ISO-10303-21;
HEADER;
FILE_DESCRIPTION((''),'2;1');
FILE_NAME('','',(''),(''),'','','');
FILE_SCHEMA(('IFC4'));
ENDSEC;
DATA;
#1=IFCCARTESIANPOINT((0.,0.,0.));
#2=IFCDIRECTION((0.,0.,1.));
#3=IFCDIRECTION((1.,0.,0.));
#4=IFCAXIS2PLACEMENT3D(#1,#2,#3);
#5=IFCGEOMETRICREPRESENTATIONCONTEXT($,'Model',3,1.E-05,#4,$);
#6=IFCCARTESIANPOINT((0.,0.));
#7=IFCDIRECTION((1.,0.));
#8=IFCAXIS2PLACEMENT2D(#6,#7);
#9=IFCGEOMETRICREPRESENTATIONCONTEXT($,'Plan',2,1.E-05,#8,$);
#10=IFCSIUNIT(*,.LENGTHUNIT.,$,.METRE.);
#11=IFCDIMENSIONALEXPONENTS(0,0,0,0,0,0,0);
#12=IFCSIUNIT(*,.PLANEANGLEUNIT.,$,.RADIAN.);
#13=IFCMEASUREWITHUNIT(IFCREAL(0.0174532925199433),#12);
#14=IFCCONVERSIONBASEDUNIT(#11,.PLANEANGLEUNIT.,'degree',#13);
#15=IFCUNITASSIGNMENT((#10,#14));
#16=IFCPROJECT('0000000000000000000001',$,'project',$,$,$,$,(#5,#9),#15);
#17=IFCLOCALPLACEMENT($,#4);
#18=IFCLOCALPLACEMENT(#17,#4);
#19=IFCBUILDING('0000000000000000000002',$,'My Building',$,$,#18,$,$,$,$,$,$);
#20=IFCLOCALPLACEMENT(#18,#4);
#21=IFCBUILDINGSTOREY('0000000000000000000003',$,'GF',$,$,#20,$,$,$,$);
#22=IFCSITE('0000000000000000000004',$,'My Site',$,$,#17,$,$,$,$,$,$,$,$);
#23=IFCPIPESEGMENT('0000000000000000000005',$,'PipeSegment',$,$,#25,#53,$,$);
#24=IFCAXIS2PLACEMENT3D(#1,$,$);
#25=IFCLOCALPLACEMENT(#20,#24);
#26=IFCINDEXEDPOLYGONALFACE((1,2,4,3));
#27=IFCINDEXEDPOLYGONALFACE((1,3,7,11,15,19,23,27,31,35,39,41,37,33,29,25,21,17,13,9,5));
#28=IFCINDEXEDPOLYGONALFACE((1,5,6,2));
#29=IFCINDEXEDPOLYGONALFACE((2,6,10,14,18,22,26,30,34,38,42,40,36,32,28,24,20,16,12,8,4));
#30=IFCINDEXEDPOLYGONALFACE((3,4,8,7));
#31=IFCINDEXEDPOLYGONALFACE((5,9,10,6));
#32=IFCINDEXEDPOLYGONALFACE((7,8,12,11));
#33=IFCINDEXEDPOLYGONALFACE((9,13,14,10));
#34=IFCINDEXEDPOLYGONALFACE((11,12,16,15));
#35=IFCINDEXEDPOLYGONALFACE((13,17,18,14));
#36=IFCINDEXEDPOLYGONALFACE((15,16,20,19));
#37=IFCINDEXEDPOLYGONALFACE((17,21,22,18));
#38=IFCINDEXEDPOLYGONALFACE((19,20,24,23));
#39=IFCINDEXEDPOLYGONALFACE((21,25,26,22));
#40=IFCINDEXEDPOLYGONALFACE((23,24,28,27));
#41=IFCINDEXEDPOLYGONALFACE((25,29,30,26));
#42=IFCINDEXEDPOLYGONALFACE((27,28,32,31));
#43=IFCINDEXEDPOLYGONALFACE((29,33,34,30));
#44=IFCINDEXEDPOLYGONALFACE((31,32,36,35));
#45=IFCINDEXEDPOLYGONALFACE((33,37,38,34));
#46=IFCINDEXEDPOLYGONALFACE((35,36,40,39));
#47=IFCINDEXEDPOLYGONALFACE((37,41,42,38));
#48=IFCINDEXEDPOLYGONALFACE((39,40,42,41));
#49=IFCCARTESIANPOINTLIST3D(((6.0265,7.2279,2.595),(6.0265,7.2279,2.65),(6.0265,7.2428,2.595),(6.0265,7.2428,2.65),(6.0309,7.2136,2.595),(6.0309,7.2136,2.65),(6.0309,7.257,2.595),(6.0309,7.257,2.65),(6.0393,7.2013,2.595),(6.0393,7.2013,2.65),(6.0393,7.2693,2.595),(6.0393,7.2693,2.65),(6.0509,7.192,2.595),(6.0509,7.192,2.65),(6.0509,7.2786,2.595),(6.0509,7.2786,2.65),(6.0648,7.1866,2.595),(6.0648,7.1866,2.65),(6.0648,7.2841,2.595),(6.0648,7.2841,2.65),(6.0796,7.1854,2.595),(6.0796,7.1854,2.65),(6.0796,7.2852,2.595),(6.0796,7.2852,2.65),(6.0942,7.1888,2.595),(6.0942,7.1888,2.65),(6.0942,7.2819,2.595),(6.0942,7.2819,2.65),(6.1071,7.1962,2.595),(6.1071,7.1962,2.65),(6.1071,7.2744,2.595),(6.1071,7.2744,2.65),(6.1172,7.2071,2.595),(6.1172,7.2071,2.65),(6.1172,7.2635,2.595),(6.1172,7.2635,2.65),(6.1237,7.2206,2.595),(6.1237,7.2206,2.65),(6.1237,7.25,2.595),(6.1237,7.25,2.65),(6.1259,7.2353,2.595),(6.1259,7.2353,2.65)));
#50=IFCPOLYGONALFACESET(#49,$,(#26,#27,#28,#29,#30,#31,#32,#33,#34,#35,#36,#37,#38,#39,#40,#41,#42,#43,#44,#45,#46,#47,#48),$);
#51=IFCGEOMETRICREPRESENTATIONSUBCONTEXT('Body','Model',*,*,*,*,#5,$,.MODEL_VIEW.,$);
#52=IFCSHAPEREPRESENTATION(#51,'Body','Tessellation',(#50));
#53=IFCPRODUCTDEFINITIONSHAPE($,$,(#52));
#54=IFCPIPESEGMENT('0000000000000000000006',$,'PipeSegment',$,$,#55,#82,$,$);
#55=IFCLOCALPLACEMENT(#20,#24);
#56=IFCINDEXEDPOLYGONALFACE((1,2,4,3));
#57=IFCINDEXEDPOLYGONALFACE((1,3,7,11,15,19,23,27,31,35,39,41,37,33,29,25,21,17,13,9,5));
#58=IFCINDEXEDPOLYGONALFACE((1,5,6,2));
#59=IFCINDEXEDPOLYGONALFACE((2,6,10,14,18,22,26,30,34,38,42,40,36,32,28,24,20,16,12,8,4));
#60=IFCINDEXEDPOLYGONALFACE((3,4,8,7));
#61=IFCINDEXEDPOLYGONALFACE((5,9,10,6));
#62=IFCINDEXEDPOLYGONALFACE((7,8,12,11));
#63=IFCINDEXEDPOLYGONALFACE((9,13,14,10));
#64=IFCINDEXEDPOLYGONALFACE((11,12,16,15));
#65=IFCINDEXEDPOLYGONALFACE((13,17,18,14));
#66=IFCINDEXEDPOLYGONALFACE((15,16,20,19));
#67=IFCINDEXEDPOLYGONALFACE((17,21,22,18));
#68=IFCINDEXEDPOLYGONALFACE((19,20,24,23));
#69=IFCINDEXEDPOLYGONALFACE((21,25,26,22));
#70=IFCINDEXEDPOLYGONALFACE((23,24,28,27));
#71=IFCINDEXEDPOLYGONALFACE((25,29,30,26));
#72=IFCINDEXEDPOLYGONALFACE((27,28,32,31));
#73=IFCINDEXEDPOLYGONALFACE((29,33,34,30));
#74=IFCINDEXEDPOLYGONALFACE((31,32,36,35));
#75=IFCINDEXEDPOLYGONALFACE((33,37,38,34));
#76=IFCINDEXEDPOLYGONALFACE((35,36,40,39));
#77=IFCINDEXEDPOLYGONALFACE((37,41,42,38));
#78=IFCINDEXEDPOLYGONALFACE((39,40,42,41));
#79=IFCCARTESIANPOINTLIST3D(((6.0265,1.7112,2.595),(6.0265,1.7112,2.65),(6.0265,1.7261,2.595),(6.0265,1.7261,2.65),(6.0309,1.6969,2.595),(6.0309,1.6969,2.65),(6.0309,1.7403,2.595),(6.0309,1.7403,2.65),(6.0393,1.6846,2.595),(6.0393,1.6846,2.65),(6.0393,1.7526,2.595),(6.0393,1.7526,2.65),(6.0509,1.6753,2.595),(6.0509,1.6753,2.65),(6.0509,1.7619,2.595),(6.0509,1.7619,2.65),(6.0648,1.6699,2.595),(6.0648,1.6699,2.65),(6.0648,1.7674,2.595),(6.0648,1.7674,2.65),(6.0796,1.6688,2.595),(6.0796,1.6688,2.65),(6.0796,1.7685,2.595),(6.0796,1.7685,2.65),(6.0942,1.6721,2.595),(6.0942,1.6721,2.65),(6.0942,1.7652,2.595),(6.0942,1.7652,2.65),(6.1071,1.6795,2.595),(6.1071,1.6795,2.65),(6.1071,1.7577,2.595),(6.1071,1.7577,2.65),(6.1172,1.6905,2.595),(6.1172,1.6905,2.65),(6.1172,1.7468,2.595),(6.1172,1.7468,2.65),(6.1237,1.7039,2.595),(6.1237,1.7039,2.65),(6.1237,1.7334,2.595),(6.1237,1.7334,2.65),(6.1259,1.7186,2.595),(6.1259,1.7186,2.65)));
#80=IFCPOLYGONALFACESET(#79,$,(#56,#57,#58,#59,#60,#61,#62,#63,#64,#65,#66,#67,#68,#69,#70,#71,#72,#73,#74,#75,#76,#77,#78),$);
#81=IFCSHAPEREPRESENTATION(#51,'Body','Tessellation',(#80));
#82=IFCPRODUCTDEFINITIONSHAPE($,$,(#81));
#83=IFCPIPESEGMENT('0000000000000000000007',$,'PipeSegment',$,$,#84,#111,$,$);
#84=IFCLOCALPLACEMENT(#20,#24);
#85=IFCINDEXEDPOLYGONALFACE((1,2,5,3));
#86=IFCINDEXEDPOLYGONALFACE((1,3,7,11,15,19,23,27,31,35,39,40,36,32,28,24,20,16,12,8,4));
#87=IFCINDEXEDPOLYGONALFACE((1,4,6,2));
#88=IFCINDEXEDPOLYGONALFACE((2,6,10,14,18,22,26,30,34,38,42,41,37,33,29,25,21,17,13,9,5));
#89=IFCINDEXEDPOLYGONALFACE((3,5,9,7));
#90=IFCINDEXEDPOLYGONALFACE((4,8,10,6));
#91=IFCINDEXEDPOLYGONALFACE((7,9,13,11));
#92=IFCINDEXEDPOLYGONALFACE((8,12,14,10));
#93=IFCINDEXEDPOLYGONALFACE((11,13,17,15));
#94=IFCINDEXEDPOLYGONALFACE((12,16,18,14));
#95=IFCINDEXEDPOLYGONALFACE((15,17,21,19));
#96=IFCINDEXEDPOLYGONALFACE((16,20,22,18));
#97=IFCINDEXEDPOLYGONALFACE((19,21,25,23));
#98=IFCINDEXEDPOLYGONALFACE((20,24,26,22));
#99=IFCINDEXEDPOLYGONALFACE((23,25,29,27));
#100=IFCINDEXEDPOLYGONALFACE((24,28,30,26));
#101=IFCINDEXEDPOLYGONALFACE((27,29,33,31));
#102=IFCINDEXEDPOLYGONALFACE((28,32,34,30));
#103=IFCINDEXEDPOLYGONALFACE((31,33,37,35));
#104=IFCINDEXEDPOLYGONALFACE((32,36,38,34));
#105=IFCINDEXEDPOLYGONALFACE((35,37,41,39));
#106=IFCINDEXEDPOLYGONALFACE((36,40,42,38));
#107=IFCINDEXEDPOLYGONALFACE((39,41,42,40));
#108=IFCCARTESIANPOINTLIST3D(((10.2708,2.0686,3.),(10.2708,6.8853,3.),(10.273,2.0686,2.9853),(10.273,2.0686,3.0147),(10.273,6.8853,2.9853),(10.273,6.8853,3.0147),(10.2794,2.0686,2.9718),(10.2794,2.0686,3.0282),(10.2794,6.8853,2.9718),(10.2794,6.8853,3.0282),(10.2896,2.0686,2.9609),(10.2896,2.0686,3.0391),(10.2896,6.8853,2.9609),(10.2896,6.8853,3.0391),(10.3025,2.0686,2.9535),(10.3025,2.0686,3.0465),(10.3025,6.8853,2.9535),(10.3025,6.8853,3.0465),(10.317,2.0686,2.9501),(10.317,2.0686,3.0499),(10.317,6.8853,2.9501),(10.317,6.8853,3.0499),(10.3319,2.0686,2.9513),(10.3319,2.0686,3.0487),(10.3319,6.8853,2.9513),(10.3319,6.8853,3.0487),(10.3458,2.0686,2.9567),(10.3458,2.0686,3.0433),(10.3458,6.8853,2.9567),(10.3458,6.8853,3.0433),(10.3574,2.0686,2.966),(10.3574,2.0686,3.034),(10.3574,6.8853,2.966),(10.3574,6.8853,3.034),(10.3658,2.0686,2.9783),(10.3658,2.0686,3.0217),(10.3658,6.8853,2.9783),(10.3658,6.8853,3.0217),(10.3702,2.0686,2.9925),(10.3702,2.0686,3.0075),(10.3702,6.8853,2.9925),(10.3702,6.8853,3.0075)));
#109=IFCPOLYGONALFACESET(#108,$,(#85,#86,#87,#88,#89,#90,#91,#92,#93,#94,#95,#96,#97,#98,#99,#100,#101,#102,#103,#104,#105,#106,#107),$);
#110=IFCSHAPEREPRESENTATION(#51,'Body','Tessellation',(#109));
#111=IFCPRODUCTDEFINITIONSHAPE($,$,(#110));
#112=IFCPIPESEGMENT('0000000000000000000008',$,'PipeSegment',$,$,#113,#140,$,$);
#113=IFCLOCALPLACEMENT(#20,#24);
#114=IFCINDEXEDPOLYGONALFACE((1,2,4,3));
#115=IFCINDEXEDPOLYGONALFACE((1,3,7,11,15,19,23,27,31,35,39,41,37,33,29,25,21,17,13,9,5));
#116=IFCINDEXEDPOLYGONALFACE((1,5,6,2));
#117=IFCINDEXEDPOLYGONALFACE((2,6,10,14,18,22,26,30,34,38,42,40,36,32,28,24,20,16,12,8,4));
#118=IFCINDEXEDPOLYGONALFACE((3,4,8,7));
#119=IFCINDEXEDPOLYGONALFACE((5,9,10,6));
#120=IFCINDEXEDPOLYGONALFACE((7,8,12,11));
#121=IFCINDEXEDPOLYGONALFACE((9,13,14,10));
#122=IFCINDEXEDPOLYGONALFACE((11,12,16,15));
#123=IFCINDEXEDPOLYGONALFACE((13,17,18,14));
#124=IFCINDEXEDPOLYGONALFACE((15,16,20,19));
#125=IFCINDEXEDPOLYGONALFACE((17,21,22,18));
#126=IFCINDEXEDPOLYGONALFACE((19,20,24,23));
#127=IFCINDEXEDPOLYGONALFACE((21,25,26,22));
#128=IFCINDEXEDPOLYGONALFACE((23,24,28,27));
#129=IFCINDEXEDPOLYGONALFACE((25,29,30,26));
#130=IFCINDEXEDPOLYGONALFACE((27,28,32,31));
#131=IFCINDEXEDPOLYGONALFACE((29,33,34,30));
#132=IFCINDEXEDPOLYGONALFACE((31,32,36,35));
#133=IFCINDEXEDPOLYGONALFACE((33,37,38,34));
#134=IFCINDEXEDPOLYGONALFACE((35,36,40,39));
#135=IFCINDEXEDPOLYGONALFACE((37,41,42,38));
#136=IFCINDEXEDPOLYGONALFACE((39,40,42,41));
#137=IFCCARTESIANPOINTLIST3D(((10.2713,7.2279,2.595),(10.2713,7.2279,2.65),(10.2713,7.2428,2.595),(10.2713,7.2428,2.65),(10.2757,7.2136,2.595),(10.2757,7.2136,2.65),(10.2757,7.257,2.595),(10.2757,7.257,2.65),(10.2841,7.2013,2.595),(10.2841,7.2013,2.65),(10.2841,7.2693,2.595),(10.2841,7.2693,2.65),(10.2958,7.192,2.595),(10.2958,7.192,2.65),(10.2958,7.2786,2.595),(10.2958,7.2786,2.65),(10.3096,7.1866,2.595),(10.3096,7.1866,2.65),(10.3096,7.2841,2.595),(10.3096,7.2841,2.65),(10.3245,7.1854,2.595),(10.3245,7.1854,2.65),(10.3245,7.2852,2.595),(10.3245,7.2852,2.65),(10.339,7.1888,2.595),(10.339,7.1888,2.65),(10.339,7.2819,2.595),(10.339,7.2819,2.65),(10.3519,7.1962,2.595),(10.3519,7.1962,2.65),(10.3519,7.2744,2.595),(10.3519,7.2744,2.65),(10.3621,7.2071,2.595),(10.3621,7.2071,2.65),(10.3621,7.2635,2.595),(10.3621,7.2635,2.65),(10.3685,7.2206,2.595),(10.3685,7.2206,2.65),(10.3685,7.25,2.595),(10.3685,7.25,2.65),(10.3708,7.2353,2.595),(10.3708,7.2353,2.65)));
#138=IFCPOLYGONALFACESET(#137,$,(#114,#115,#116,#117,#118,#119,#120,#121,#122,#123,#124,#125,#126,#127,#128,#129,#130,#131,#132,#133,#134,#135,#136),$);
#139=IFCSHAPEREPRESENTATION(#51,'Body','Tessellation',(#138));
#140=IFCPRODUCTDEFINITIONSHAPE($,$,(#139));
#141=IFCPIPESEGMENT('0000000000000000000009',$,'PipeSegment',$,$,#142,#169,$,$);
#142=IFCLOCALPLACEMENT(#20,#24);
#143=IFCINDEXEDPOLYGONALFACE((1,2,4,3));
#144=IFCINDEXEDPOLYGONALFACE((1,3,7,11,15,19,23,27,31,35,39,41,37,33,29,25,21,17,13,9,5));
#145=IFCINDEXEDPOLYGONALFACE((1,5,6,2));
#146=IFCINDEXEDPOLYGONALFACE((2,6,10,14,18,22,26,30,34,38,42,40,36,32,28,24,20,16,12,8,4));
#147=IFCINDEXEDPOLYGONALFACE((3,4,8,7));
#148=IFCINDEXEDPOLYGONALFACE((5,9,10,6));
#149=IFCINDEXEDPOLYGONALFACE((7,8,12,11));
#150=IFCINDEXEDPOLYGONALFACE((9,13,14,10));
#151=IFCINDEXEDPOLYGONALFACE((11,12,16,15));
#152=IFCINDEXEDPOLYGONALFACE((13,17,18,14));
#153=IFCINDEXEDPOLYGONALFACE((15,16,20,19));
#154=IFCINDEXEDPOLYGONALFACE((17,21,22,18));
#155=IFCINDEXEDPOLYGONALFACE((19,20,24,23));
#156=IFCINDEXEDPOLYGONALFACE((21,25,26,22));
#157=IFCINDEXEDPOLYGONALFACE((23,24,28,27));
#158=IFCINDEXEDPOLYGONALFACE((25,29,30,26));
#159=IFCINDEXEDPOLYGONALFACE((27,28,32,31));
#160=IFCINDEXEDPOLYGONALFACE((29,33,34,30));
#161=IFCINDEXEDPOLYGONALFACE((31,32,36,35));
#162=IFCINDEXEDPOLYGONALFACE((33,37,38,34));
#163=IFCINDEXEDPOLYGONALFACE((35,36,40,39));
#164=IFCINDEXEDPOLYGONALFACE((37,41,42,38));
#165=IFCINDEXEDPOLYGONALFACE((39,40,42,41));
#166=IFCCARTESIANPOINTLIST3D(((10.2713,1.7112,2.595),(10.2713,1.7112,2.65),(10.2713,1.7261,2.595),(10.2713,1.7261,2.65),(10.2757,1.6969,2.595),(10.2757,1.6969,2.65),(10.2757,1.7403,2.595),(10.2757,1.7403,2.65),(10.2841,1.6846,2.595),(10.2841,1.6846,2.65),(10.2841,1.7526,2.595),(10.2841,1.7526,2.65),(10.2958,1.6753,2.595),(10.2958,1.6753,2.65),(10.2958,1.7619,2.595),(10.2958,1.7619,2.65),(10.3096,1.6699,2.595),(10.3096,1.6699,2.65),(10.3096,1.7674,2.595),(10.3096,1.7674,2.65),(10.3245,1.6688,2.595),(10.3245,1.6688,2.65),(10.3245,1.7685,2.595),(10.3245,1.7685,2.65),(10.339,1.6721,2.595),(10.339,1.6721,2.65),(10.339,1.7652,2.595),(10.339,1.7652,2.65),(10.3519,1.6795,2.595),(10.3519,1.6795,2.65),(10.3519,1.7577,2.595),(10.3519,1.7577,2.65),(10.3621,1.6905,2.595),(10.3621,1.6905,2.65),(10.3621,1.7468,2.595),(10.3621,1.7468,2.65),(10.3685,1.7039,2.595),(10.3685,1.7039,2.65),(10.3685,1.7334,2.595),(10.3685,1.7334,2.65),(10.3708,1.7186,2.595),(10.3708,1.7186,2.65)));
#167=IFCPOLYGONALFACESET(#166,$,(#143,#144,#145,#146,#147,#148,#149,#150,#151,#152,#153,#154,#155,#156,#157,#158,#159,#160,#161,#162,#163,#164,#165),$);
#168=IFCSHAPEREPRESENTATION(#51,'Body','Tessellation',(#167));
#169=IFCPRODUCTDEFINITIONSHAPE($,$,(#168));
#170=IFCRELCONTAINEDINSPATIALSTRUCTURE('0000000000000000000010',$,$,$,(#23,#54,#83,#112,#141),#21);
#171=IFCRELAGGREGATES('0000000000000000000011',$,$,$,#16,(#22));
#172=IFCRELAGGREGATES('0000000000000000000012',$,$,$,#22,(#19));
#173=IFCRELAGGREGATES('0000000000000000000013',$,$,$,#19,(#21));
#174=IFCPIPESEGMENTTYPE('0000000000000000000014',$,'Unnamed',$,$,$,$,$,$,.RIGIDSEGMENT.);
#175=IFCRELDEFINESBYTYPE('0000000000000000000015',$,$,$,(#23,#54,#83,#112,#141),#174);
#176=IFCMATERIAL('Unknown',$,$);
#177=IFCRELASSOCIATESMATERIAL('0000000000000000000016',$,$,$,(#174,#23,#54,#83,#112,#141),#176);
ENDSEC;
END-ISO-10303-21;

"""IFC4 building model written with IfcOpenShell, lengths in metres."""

from ifc_helpers import new_model, entity, si_unit, converted_unit, frame, origin_with_axes, origin_2d_with_axis, place, context, subcontext, project, spatial, circle, extrude, material, material_profile, profile_set, profile_usage, type_object, element, save


model = new_model("IFC4")

# Units and contexts
model_context = context("Model", 3, precision=1e-05, world=origin_with_axes())
plan_context = context("Plan", 2, precision=1e-05, world=origin_2d_with_axis())
body_context = subcontext(model_context, "Body", "Model", "MODEL_VIEW")
ifc_project = project(units=[si_unit("LENGTHUNIT", "METRE"), converted_unit("PLANEANGLEUNIT", "degree", entity("IfcReal", 0.0174532925199433), si_unit("PLANEANGLEUNIT", "RADIAN"), dimensions=[0, 0, 0, 0, 0, 0, 0])], contexts=[model_context, plan_context])

# Site, building, storey
site_placement = place(None, origin_with_axes())
site = spatial("IfcSite", under=ifc_project, at=site_placement, Name="My Site")
building_placement = place(site_placement, origin_with_axes())
building = spatial("IfcBuilding", under=site, at=building_placement, Name="My Building")
storey_placement = place(building_placement, origin_with_axes())
storey = spatial("IfcBuildingStorey", under=building, at=storey_placement, Name="GF")

# Pipe segments
ifc_material = material(Name="Unknown")
ifc_material_profile = material_profile(ifc_material, circle(Radius=0.05))
ifc_profile_set = profile_set([ifc_material_profile])
ifc_profile_usage_1 = profile_usage(ifc_profile_set, cardinal=5)
pipe_segment_type = type_object("IfcPipeSegmentType", Name="Unnamed", PredefinedType="RIGIDSEGMENT", material=ifc_profile_set)
pipe_segment_1_placement = place(storey_placement, frame((6.0759, 7.2353, 2.65), z_axis=(0.0, 0.0, -1.0), x_axis=(1.0, 0.0, 0.0)))
element("IfcPipeSegment", 1, at=pipe_segment_1_placement, inside=storey, type_object=pipe_segment_type, material=ifc_profile_usage_1, Name="PipeSegment", context=body_context, shape_type="SweptSolid", body=[
    extrude(circle(Radius=0.05), origin_with_axes(), (0.0, 0.0, 1.0), 0.055),
])
ifc_profile_usage_2 = profile_usage(ifc_profile_set, cardinal=5)
pipe_segment_2_placement = place(storey_placement, frame((6.0759, 1.7186, 2.65), z_axis=(0.0, 0.0, -1.0), x_axis=(1.0, 0.0, 0.0)))
element("IfcPipeSegment", 2, at=pipe_segment_2_placement, inside=storey, type_object=pipe_segment_type, material=ifc_profile_usage_2, Name="PipeSegment", context=body_context, shape_type="SweptSolid", body=[
    extrude(circle(Radius=0.05), origin_with_axes(), (0.0, 0.0, 1.0), 0.055),
])
ifc_profile_usage_3 = profile_usage(ifc_profile_set, cardinal=5)
pipe_segment_3_placement = place(storey_placement, frame((10.3208, 6.8853, 3.0), z_axis=(0.0, -1.0, 0.0), x_axis=(-1.0, 0.0, 0.0)))
element("IfcPipeSegment", 3, at=pipe_segment_3_placement, inside=storey, type_object=pipe_segment_type, material=ifc_profile_usage_3, Name="PipeSegment", context=body_context, shape_type="SweptSolid", body=[
    extrude(circle(Radius=0.05), origin_with_axes(), (0.0, 0.0, 1.0), 4.8167),
])
ifc_profile_usage_4 = profile_usage(ifc_profile_set, cardinal=5)
pipe_segment_4_placement = place(storey_placement, frame((10.3208, 7.2353, 2.65), z_axis=(0.0, 0.0, -1.0), x_axis=(1.0, 0.0, 0.0)))
element("IfcPipeSegment", 4, at=pipe_segment_4_placement, inside=storey, type_object=pipe_segment_type, material=ifc_profile_usage_4, Name="PipeSegment", context=body_context, shape_type="SweptSolid", body=[
    extrude(circle(Radius=0.05), origin_with_axes(), (0.0, 0.0, 1.0), 0.055),
])
ifc_profile_usage_5 = profile_usage(ifc_profile_set, cardinal=5)
pipe_segment_5_placement = place(storey_placement, frame((10.3208, 1.7186, 2.65), z_axis=(0.0, 0.0, -1.0), x_axis=(1.0, 0.0, 0.0)))
element("IfcPipeSegment", 5, at=pipe_segment_5_placement, inside=storey, type_object=pipe_segment_type, material=ifc_profile_usage_5, Name="PipeSegment", context=body_context, shape_type="SweptSolid", body=[
    extrude(circle(Radius=0.05), origin_with_axes(), (0.0, 0.0, 1.0), 0.055),
])

save(model, "model.ifc")
